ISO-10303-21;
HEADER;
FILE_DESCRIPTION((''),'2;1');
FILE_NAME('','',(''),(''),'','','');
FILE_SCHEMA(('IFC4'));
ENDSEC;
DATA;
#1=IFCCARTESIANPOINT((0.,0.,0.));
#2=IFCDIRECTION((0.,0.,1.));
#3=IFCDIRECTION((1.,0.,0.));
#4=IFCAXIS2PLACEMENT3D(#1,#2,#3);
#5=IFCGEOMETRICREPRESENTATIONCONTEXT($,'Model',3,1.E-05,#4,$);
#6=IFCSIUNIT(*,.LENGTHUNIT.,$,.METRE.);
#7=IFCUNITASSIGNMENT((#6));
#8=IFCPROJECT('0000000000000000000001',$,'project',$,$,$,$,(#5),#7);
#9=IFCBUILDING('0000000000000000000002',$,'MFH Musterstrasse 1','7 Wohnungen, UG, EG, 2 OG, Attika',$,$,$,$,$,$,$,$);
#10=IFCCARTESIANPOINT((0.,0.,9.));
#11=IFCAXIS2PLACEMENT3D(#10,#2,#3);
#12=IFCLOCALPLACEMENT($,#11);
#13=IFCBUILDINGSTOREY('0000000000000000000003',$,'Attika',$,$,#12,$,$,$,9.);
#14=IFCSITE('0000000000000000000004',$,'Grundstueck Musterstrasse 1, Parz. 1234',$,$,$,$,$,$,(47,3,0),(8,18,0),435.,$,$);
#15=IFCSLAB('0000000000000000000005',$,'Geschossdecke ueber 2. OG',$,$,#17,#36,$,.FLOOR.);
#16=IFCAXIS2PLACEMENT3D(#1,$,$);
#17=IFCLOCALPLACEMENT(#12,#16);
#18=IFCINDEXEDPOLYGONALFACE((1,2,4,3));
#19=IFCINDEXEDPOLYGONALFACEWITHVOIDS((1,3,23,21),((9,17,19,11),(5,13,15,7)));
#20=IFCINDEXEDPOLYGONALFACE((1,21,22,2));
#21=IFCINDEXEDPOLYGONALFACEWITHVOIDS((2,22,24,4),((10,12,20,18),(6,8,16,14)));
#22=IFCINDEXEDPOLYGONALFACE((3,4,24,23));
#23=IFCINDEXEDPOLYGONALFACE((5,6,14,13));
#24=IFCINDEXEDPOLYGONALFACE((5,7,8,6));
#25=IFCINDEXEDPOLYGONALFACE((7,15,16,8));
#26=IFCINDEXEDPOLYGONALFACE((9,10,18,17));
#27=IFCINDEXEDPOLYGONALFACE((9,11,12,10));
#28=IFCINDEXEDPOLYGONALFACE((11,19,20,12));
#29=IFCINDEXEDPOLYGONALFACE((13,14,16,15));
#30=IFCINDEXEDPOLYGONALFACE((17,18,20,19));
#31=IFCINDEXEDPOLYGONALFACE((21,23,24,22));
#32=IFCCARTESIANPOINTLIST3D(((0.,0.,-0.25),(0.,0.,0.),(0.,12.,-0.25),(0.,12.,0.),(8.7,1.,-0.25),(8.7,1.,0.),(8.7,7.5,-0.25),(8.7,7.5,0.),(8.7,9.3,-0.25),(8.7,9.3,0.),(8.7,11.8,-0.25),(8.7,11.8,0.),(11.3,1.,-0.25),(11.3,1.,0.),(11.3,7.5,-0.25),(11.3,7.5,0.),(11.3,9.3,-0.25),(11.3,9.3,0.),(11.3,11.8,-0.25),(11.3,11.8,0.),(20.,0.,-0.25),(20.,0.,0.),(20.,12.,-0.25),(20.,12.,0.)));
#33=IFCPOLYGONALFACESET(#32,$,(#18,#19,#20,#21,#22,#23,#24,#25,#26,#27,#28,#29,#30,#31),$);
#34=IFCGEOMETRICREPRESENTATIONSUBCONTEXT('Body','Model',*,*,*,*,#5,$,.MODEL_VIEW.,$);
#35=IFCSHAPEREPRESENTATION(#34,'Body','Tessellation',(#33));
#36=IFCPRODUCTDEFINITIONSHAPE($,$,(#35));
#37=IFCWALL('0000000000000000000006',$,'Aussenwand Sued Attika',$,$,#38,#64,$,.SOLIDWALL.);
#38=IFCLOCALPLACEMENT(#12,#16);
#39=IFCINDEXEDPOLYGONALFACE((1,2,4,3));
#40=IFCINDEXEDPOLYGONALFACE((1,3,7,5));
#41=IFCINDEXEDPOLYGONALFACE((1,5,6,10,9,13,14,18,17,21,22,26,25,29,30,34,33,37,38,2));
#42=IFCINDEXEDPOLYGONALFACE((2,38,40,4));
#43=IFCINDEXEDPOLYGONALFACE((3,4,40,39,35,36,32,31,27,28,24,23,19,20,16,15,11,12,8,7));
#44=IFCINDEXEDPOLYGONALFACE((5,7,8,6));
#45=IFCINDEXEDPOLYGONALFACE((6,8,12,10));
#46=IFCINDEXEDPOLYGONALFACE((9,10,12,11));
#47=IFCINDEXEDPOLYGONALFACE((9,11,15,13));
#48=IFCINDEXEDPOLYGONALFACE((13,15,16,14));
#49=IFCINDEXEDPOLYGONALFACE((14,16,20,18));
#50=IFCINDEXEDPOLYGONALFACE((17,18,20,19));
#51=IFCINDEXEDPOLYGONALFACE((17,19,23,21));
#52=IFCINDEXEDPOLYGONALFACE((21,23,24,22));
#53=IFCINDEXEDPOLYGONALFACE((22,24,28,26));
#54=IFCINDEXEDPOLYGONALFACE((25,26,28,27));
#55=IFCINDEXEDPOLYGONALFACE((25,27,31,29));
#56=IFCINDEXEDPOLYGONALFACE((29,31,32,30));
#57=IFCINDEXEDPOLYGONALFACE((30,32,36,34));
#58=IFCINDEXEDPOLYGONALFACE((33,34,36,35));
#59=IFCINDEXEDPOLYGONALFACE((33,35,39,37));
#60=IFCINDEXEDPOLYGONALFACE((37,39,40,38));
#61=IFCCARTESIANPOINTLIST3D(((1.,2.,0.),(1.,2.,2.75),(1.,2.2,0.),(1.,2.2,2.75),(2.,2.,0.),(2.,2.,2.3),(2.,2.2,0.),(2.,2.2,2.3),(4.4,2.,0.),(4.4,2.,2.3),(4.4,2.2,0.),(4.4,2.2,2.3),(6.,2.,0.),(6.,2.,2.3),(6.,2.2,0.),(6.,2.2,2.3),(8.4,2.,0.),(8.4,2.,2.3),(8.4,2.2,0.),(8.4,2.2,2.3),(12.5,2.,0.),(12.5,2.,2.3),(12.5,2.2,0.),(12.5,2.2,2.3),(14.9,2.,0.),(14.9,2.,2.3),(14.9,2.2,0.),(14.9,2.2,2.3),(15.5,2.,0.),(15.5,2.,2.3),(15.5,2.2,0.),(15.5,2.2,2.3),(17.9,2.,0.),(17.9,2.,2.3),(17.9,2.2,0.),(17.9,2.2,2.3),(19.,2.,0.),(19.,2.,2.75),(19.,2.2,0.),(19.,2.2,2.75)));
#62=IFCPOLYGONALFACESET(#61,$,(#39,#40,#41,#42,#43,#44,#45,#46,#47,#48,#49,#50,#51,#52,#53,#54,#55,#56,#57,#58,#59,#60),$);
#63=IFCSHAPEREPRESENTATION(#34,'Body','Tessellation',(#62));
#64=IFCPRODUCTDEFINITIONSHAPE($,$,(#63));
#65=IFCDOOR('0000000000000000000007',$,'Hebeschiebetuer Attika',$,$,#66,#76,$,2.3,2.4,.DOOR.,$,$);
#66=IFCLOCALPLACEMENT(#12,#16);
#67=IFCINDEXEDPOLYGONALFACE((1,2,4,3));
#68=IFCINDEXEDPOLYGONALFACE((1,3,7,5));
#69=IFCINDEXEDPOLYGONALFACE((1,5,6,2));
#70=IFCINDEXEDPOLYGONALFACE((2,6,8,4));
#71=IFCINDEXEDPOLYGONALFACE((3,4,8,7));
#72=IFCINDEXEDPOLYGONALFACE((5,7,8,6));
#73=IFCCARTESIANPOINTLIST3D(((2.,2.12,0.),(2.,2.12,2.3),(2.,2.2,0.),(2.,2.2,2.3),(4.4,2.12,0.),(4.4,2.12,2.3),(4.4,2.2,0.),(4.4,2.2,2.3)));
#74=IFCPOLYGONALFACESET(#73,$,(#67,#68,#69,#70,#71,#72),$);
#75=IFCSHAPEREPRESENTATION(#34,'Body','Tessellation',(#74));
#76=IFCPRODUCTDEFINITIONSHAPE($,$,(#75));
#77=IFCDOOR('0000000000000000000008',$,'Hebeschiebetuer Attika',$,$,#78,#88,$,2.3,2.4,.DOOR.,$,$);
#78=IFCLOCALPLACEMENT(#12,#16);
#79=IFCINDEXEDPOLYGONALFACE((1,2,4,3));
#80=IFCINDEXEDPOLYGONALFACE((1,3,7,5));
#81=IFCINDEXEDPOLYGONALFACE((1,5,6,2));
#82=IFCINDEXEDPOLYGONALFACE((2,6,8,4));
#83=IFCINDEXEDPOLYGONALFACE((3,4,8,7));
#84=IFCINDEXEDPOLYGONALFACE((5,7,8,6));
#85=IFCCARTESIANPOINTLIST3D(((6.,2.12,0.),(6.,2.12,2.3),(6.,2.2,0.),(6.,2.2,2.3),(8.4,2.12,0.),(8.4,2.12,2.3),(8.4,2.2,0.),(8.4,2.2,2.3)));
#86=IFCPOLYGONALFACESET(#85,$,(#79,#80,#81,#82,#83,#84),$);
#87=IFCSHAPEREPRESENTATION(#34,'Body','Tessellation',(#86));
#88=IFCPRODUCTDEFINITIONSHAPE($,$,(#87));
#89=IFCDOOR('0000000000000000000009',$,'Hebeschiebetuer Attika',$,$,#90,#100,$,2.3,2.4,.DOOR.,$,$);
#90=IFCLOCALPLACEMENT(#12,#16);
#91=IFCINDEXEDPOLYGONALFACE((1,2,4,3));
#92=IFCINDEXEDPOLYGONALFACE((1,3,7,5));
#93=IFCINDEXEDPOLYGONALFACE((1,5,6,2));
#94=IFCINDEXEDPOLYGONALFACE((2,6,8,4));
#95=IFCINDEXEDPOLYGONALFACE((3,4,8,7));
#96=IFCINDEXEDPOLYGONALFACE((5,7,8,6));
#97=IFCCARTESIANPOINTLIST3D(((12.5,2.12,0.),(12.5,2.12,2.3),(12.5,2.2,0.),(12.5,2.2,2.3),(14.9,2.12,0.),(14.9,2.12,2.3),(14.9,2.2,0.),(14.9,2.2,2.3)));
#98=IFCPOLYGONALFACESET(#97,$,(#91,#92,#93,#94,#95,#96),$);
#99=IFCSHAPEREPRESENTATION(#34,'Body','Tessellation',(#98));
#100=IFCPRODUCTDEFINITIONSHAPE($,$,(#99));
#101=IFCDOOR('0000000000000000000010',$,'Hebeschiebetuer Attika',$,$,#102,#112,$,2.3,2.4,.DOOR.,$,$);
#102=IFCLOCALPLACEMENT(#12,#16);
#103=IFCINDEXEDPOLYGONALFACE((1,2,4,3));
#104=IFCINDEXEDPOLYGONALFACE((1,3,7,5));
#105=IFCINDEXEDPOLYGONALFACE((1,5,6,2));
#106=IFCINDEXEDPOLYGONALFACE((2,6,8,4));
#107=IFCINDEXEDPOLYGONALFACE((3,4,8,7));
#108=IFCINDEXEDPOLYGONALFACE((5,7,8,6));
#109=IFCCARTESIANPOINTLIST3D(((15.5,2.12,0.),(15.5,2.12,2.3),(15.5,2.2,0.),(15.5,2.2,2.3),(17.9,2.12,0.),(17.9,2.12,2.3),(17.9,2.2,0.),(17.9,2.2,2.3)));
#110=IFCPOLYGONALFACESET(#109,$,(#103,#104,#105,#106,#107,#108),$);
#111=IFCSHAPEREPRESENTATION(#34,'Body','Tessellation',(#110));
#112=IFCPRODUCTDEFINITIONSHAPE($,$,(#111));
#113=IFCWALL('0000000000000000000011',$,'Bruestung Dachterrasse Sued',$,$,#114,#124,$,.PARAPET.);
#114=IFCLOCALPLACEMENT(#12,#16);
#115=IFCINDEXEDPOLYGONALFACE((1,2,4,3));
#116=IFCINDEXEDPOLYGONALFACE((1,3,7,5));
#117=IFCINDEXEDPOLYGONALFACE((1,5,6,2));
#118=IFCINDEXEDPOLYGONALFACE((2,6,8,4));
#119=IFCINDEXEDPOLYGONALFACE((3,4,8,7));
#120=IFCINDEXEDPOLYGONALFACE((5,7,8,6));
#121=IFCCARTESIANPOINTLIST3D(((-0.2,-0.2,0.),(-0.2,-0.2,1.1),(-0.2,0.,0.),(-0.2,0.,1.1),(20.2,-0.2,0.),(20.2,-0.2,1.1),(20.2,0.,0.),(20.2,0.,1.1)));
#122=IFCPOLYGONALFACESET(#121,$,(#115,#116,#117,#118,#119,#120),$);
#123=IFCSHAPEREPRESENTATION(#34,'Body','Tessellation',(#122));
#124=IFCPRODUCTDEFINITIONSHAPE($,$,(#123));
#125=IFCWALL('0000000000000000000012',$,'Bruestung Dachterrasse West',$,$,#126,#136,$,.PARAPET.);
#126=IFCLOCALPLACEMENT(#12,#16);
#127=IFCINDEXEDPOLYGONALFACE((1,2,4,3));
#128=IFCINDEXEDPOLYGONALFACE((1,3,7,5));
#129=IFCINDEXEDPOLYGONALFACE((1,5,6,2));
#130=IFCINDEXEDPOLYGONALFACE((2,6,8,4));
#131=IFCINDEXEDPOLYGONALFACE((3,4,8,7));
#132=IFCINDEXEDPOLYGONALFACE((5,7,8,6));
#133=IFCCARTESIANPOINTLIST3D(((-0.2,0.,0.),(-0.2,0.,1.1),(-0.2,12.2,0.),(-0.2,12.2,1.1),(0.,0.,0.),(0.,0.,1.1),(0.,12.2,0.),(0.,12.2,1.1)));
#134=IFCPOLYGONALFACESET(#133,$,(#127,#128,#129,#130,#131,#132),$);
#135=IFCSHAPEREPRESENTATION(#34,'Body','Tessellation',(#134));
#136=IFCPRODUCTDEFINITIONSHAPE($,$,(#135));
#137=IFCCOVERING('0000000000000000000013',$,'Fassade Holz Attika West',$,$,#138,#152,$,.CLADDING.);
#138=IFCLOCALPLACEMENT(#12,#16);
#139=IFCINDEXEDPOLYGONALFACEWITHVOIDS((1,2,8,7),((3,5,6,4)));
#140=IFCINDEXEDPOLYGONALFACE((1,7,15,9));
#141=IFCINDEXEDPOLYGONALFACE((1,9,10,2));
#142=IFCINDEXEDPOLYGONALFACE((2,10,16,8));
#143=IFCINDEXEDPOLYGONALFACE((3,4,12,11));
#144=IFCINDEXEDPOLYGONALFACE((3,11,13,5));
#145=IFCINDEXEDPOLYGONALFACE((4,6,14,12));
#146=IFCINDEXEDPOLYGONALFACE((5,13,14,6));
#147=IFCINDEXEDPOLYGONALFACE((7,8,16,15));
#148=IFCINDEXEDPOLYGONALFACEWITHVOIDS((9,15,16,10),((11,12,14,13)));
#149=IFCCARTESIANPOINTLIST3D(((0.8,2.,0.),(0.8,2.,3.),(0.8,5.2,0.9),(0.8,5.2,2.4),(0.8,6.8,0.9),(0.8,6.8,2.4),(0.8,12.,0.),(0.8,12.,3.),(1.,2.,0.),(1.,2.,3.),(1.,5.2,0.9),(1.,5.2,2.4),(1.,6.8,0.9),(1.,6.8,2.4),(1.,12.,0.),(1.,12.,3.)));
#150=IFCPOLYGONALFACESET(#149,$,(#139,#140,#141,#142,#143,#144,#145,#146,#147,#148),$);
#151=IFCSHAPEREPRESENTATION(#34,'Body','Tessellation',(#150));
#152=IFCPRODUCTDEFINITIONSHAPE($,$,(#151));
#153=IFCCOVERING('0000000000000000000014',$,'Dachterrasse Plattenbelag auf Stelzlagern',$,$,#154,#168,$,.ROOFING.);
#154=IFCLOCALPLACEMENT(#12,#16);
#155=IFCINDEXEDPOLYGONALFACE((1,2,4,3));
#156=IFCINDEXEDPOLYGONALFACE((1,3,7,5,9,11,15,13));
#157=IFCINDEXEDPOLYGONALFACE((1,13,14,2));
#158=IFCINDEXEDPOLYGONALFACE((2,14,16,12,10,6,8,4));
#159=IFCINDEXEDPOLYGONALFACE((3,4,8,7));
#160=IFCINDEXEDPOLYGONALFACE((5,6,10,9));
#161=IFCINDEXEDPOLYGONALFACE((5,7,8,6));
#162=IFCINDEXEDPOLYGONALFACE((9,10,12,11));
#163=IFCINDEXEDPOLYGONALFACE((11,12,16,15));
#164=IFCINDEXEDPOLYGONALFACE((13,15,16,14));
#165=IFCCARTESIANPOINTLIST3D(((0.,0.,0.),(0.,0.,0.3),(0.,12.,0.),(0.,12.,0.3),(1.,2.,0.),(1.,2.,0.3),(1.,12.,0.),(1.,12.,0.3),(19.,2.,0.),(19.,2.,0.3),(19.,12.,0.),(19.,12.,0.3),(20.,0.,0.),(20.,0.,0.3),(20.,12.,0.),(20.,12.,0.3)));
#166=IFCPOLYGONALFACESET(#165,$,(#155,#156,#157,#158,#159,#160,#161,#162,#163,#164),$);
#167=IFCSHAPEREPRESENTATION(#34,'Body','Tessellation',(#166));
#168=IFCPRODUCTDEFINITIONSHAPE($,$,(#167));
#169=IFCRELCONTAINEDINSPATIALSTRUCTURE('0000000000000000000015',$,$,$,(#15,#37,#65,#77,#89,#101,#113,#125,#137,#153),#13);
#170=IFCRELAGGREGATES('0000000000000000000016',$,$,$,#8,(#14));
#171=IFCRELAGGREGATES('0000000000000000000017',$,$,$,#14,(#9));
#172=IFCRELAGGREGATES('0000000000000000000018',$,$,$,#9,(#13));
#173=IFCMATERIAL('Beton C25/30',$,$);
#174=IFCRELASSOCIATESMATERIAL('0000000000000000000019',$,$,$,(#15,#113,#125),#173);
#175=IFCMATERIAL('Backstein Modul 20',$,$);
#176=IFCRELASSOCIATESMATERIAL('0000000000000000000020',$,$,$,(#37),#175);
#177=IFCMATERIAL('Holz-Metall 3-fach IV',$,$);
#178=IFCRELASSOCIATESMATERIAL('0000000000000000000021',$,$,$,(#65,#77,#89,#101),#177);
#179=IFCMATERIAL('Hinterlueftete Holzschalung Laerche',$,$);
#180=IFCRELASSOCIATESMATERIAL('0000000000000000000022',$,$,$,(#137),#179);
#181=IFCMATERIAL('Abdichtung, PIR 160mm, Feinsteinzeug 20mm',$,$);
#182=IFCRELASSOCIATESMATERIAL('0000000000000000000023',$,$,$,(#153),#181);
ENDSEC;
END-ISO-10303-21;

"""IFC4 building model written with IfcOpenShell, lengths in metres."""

from ifc_helpers import new_model, si_unit, frame, frame_2d, origin_with_axes, place, context, subcontext, project, spatial, polyline, rectangle, outline, extrude, material, element, fill, save


model = new_model("IFC4")

# Units and contexts
model_context = context("Model", 3, precision=1e-05, world=origin_with_axes())
body_context = subcontext(model_context, "Body", "Model", "MODEL_VIEW")
ifc_project = project(units=[si_unit("LENGTHUNIT", "METRE")], contexts=[model_context])

# Site, building, storey
site = spatial("IfcSite", under=ifc_project, Name="Grundstueck Musterstrasse 1, Parz. 1234", RefLatitude=(47, 3, 0), RefLongitude=(8, 18, 0), RefElevation=435.0)
building = spatial("IfcBuilding", under=site, Name="MFH Musterstrasse 1", Description="7 Wohnungen, UG, EG, 2 OG, Attika")
storey_placement = place(None, frame((0.0, 0.0, 9.0), z_axis=(0.0, 0.0, 1.0), x_axis=(1.0, 0.0, 0.0)))
storey = spatial("IfcBuildingStorey", under=building, at=storey_placement, Name="Attika", Elevation=9.0)

# Slab, openings
ifc_material_1 = material(Name="Beton C25/30")
slab_placement = place(storey_placement, frame((0.0, 0.0, -0.25), z_axis=(0.0, 0.0, 1.0), x_axis=(1.0, 0.0, 0.0)))
slab = element("IfcSlab", 1, at=slab_placement, inside=storey, material=ifc_material_1, Name="Geschossdecke ueber 2. OG", PredefinedType="FLOOR", context=body_context, shape_type="SweptSolid", body=[
    extrude(outline(polyline([(0.0, 0.0), (20.0, 0.0), (20.0, 12.0), (0.0, 12.0), (0.0, 0.0)])), origin_with_axes(), (0.0, 0.0, 1.0), 0.25),
])
opening_1_placement = place(slab_placement, frame((8.7, 1.0, -0.01), z_axis=(0.0, 0.0, 1.0), x_axis=(1.0, 0.0, 0.0)))
element("IfcOpeningElement", 2, at=opening_1_placement, cuts=slab, context=body_context, shape_type="SweptSolid", body=[
    extrude(rectangle(XDim=2.6, YDim=6.5, at=frame_2d((1.3, 3.25))), origin_with_axes(), (0.0, 0.0, 1.0), 0.27),
])
opening_2_placement = place(slab_placement, frame((8.7, 9.3, -0.01), z_axis=(0.0, 0.0, 1.0), x_axis=(1.0, 0.0, 0.0)))
element("IfcOpeningElement", 3, at=opening_2_placement, cuts=slab, context=body_context, shape_type="SweptSolid", body=[
    extrude(rectangle(XDim=2.6, YDim=2.5, at=frame_2d((1.3, 1.25))), origin_with_axes(), (0.0, 0.0, 1.0), 0.27),
])

# Wall, openings, doors
ifc_material_2 = material(Name="Backstein Modul 20")
wall_1_placement = place(storey_placement, frame((1.0, 2.0, 0.0), z_axis=(0.0, 0.0, 1.0), x_axis=(1.0, 0.0, 0.0)))
wall_1 = element("IfcWall", 4, at=wall_1_placement, inside=storey, material=ifc_material_2, Name="Aussenwand Sued Attika", PredefinedType="SOLIDWALL", context=body_context, shape_type="SweptSolid", body=[
    extrude(rectangle(XDim=18.0, YDim=0.2, at=frame_2d((9.0, 0.1))), origin_with_axes(), (0.0, 0.0, 1.0), 2.75),
])
opening_3_placement = place(wall_1_placement, frame((1.0, -0.21, 0.0), z_axis=(0.0, 0.0, 1.0), x_axis=(1.0, 0.0, 0.0)))
opening_3 = element("IfcOpeningElement", 5, at=opening_3_placement, cuts=wall_1, context=body_context, shape_type="SweptSolid", body=[
    extrude(rectangle(XDim=2.4, YDim=0.42, at=frame_2d((1.2, 0.21))), origin_with_axes(), (0.0, 0.0, 1.0), 2.3),
])
opening_4_placement = place(wall_1_placement, frame((5.0, -0.21, 0.0), z_axis=(0.0, 0.0, 1.0), x_axis=(1.0, 0.0, 0.0)))
opening_4 = element("IfcOpeningElement", 6, at=opening_4_placement, cuts=wall_1, context=body_context, shape_type="SweptSolid", body=[
    extrude(rectangle(XDim=2.4, YDim=0.42, at=frame_2d((1.2, 0.21))), origin_with_axes(), (0.0, 0.0, 1.0), 2.3),
])
opening_5_placement = place(wall_1_placement, frame((11.5, -0.21, 0.0), z_axis=(0.0, 0.0, 1.0), x_axis=(1.0, 0.0, 0.0)))
opening_5 = element("IfcOpeningElement", 7, at=opening_5_placement, cuts=wall_1, context=body_context, shape_type="SweptSolid", body=[
    extrude(rectangle(XDim=2.4, YDim=0.42, at=frame_2d((1.2, 0.21))), origin_with_axes(), (0.0, 0.0, 1.0), 2.3),
])
opening_6_placement = place(wall_1_placement, frame((14.5, -0.21, 0.0), z_axis=(0.0, 0.0, 1.0), x_axis=(1.0, 0.0, 0.0)))
opening_6 = element("IfcOpeningElement", 8, at=opening_6_placement, cuts=wall_1, context=body_context, shape_type="SweptSolid", body=[
    extrude(rectangle(XDim=2.4, YDim=0.42, at=frame_2d((1.2, 0.21))), origin_with_axes(), (0.0, 0.0, 1.0), 2.3),
])
ifc_material_3 = material(Name="Holz-Metall 3-fach IV")
door_1_placement = place(storey_placement, frame((2.0, 2.12, 0.0), z_axis=(0.0, 0.0, 1.0), x_axis=(1.0, 0.0, 0.0)))
door_1 = element("IfcDoor", 9, at=door_1_placement, inside=storey, material=ifc_material_3, Name="Hebeschiebetuer Attika", OverallHeight=2.3, OverallWidth=2.4, PredefinedType="DOOR", context=body_context, shape_type="SweptSolid", body=[
    extrude(rectangle(XDim=2.4, YDim=0.08, at=frame_2d((1.2, 0.04))), origin_with_axes(), (0.0, 0.0, 1.0), 2.3),
])
fill(opening_3, door_1)
door_2_placement = place(storey_placement, frame((6.0, 2.12, 0.0), z_axis=(0.0, 0.0, 1.0), x_axis=(1.0, 0.0, 0.0)))
door_2 = element("IfcDoor", 10, at=door_2_placement, inside=storey, material=ifc_material_3, Name="Hebeschiebetuer Attika", OverallHeight=2.3, OverallWidth=2.4, PredefinedType="DOOR", context=body_context, shape_type="SweptSolid", body=[
    extrude(rectangle(XDim=2.4, YDim=0.08, at=frame_2d((1.2, 0.04))), origin_with_axes(), (0.0, 0.0, 1.0), 2.3),
])
fill(opening_4, door_2)
door_3_placement = place(storey_placement, frame((12.5, 2.12, 0.0), z_axis=(0.0, 0.0, 1.0), x_axis=(1.0, 0.0, 0.0)))
door_3 = element("IfcDoor", 11, at=door_3_placement, inside=storey, material=ifc_material_3, Name="Hebeschiebetuer Attika", OverallHeight=2.3, OverallWidth=2.4, PredefinedType="DOOR", context=body_context, shape_type="SweptSolid", body=[
    extrude(rectangle(XDim=2.4, YDim=0.08, at=frame_2d((1.2, 0.04))), origin_with_axes(), (0.0, 0.0, 1.0), 2.3),
])
fill(opening_5, door_3)
door_4_placement = place(storey_placement, frame((15.5, 2.12, 0.0), z_axis=(0.0, 0.0, 1.0), x_axis=(1.0, 0.0, 0.0)))
door_4 = element("IfcDoor", 12, at=door_4_placement, inside=storey, material=ifc_material_3, Name="Hebeschiebetuer Attika", OverallHeight=2.3, OverallWidth=2.4, PredefinedType="DOOR", context=body_context, shape_type="SweptSolid", body=[
    extrude(rectangle(XDim=2.4, YDim=0.08, at=frame_2d((1.2, 0.04))), origin_with_axes(), (0.0, 0.0, 1.0), 2.3),
])
fill(opening_6, door_4)

# Walls
wall_2_placement = place(storey_placement, frame((-0.2, -0.2, 0.0), z_axis=(0.0, 0.0, 1.0), x_axis=(1.0, 0.0, 0.0)))
element("IfcWall", 13, at=wall_2_placement, inside=storey, material=ifc_material_1, Name="Bruestung Dachterrasse Sued", PredefinedType="PARAPET", context=body_context, shape_type="SweptSolid", body=[
    extrude(rectangle(XDim=20.4, YDim=0.2, at=frame_2d((10.2, 0.1))), origin_with_axes(), (0.0, 0.0, 1.0), 1.1),
])
wall_3_placement = place(storey_placement, frame((-0.2, 0.0, 0.0), z_axis=(0.0, 0.0, 1.0), x_axis=(1.0, 0.0, 0.0)))
element("IfcWall", 14, at=wall_3_placement, inside=storey, material=ifc_material_1, Name="Bruestung Dachterrasse West", PredefinedType="PARAPET", context=body_context, shape_type="SweptSolid", body=[
    extrude(rectangle(XDim=0.2, YDim=12.2, at=frame_2d((0.1, 6.1))), origin_with_axes(), (0.0, 0.0, 1.0), 1.1),
])

# Shared definitions
ifc_material_4 = material(Name="Hinterlueftete Holzschalung Laerche")

# Covering, opening
covering_1_placement = place(storey_placement, frame((0.8, 2.0, 0.0), z_axis=(0.0, 0.0, 1.0), x_axis=(1.0, 0.0, 0.0)))
covering_1 = element("IfcCovering", 15, at=covering_1_placement, inside=storey, material=ifc_material_4, Name="Fassade Holz Attika West", PredefinedType="CLADDING", context=body_context, shape_type="SweptSolid", body=[
    extrude(rectangle(XDim=0.2, YDim=10.0, at=frame_2d((0.1, 5.0))), origin_with_axes(), (0.0, 0.0, 1.0), 3.0),
])
opening_7_placement = place(covering_1_placement, frame((-0.01, 3.2, 0.9), z_axis=(0.0, 0.0, 1.0), x_axis=(1.0, 0.0, 0.0)))
element("IfcOpeningElement", 16, at=opening_7_placement, cuts=covering_1, context=body_context, shape_type="SweptSolid", body=[
    extrude(rectangle(XDim=0.42, YDim=1.6, at=frame_2d((0.21, 0.8))), origin_with_axes(), (0.0, 0.0, 1.0), 1.5),
])

# Covering
ifc_material_5 = material(Name="Abdichtung, PIR 160mm, Feinsteinzeug 20mm")
covering_2_placement = place(storey_placement, origin_with_axes())
element("IfcCovering", 17, at=covering_2_placement, inside=storey, material=ifc_material_5, Name="Dachterrasse Plattenbelag auf Stelzlagern", PredefinedType="ROOFING", context=body_context, shape_type="SweptSolid", body=[
    extrude(outline(polyline([(0.0, 0.0), (20.0, 0.0), (20.0, 12.0), (19.0, 12.0), (19.0, 2.0), (1.0, 2.0), (1.0, 12.0), (0.0, 12.0), (0.0, 0.0)])), origin_with_axes(), (0.0, 0.0, 1.0), 0.3),
])

save(model, "model.ifc")
